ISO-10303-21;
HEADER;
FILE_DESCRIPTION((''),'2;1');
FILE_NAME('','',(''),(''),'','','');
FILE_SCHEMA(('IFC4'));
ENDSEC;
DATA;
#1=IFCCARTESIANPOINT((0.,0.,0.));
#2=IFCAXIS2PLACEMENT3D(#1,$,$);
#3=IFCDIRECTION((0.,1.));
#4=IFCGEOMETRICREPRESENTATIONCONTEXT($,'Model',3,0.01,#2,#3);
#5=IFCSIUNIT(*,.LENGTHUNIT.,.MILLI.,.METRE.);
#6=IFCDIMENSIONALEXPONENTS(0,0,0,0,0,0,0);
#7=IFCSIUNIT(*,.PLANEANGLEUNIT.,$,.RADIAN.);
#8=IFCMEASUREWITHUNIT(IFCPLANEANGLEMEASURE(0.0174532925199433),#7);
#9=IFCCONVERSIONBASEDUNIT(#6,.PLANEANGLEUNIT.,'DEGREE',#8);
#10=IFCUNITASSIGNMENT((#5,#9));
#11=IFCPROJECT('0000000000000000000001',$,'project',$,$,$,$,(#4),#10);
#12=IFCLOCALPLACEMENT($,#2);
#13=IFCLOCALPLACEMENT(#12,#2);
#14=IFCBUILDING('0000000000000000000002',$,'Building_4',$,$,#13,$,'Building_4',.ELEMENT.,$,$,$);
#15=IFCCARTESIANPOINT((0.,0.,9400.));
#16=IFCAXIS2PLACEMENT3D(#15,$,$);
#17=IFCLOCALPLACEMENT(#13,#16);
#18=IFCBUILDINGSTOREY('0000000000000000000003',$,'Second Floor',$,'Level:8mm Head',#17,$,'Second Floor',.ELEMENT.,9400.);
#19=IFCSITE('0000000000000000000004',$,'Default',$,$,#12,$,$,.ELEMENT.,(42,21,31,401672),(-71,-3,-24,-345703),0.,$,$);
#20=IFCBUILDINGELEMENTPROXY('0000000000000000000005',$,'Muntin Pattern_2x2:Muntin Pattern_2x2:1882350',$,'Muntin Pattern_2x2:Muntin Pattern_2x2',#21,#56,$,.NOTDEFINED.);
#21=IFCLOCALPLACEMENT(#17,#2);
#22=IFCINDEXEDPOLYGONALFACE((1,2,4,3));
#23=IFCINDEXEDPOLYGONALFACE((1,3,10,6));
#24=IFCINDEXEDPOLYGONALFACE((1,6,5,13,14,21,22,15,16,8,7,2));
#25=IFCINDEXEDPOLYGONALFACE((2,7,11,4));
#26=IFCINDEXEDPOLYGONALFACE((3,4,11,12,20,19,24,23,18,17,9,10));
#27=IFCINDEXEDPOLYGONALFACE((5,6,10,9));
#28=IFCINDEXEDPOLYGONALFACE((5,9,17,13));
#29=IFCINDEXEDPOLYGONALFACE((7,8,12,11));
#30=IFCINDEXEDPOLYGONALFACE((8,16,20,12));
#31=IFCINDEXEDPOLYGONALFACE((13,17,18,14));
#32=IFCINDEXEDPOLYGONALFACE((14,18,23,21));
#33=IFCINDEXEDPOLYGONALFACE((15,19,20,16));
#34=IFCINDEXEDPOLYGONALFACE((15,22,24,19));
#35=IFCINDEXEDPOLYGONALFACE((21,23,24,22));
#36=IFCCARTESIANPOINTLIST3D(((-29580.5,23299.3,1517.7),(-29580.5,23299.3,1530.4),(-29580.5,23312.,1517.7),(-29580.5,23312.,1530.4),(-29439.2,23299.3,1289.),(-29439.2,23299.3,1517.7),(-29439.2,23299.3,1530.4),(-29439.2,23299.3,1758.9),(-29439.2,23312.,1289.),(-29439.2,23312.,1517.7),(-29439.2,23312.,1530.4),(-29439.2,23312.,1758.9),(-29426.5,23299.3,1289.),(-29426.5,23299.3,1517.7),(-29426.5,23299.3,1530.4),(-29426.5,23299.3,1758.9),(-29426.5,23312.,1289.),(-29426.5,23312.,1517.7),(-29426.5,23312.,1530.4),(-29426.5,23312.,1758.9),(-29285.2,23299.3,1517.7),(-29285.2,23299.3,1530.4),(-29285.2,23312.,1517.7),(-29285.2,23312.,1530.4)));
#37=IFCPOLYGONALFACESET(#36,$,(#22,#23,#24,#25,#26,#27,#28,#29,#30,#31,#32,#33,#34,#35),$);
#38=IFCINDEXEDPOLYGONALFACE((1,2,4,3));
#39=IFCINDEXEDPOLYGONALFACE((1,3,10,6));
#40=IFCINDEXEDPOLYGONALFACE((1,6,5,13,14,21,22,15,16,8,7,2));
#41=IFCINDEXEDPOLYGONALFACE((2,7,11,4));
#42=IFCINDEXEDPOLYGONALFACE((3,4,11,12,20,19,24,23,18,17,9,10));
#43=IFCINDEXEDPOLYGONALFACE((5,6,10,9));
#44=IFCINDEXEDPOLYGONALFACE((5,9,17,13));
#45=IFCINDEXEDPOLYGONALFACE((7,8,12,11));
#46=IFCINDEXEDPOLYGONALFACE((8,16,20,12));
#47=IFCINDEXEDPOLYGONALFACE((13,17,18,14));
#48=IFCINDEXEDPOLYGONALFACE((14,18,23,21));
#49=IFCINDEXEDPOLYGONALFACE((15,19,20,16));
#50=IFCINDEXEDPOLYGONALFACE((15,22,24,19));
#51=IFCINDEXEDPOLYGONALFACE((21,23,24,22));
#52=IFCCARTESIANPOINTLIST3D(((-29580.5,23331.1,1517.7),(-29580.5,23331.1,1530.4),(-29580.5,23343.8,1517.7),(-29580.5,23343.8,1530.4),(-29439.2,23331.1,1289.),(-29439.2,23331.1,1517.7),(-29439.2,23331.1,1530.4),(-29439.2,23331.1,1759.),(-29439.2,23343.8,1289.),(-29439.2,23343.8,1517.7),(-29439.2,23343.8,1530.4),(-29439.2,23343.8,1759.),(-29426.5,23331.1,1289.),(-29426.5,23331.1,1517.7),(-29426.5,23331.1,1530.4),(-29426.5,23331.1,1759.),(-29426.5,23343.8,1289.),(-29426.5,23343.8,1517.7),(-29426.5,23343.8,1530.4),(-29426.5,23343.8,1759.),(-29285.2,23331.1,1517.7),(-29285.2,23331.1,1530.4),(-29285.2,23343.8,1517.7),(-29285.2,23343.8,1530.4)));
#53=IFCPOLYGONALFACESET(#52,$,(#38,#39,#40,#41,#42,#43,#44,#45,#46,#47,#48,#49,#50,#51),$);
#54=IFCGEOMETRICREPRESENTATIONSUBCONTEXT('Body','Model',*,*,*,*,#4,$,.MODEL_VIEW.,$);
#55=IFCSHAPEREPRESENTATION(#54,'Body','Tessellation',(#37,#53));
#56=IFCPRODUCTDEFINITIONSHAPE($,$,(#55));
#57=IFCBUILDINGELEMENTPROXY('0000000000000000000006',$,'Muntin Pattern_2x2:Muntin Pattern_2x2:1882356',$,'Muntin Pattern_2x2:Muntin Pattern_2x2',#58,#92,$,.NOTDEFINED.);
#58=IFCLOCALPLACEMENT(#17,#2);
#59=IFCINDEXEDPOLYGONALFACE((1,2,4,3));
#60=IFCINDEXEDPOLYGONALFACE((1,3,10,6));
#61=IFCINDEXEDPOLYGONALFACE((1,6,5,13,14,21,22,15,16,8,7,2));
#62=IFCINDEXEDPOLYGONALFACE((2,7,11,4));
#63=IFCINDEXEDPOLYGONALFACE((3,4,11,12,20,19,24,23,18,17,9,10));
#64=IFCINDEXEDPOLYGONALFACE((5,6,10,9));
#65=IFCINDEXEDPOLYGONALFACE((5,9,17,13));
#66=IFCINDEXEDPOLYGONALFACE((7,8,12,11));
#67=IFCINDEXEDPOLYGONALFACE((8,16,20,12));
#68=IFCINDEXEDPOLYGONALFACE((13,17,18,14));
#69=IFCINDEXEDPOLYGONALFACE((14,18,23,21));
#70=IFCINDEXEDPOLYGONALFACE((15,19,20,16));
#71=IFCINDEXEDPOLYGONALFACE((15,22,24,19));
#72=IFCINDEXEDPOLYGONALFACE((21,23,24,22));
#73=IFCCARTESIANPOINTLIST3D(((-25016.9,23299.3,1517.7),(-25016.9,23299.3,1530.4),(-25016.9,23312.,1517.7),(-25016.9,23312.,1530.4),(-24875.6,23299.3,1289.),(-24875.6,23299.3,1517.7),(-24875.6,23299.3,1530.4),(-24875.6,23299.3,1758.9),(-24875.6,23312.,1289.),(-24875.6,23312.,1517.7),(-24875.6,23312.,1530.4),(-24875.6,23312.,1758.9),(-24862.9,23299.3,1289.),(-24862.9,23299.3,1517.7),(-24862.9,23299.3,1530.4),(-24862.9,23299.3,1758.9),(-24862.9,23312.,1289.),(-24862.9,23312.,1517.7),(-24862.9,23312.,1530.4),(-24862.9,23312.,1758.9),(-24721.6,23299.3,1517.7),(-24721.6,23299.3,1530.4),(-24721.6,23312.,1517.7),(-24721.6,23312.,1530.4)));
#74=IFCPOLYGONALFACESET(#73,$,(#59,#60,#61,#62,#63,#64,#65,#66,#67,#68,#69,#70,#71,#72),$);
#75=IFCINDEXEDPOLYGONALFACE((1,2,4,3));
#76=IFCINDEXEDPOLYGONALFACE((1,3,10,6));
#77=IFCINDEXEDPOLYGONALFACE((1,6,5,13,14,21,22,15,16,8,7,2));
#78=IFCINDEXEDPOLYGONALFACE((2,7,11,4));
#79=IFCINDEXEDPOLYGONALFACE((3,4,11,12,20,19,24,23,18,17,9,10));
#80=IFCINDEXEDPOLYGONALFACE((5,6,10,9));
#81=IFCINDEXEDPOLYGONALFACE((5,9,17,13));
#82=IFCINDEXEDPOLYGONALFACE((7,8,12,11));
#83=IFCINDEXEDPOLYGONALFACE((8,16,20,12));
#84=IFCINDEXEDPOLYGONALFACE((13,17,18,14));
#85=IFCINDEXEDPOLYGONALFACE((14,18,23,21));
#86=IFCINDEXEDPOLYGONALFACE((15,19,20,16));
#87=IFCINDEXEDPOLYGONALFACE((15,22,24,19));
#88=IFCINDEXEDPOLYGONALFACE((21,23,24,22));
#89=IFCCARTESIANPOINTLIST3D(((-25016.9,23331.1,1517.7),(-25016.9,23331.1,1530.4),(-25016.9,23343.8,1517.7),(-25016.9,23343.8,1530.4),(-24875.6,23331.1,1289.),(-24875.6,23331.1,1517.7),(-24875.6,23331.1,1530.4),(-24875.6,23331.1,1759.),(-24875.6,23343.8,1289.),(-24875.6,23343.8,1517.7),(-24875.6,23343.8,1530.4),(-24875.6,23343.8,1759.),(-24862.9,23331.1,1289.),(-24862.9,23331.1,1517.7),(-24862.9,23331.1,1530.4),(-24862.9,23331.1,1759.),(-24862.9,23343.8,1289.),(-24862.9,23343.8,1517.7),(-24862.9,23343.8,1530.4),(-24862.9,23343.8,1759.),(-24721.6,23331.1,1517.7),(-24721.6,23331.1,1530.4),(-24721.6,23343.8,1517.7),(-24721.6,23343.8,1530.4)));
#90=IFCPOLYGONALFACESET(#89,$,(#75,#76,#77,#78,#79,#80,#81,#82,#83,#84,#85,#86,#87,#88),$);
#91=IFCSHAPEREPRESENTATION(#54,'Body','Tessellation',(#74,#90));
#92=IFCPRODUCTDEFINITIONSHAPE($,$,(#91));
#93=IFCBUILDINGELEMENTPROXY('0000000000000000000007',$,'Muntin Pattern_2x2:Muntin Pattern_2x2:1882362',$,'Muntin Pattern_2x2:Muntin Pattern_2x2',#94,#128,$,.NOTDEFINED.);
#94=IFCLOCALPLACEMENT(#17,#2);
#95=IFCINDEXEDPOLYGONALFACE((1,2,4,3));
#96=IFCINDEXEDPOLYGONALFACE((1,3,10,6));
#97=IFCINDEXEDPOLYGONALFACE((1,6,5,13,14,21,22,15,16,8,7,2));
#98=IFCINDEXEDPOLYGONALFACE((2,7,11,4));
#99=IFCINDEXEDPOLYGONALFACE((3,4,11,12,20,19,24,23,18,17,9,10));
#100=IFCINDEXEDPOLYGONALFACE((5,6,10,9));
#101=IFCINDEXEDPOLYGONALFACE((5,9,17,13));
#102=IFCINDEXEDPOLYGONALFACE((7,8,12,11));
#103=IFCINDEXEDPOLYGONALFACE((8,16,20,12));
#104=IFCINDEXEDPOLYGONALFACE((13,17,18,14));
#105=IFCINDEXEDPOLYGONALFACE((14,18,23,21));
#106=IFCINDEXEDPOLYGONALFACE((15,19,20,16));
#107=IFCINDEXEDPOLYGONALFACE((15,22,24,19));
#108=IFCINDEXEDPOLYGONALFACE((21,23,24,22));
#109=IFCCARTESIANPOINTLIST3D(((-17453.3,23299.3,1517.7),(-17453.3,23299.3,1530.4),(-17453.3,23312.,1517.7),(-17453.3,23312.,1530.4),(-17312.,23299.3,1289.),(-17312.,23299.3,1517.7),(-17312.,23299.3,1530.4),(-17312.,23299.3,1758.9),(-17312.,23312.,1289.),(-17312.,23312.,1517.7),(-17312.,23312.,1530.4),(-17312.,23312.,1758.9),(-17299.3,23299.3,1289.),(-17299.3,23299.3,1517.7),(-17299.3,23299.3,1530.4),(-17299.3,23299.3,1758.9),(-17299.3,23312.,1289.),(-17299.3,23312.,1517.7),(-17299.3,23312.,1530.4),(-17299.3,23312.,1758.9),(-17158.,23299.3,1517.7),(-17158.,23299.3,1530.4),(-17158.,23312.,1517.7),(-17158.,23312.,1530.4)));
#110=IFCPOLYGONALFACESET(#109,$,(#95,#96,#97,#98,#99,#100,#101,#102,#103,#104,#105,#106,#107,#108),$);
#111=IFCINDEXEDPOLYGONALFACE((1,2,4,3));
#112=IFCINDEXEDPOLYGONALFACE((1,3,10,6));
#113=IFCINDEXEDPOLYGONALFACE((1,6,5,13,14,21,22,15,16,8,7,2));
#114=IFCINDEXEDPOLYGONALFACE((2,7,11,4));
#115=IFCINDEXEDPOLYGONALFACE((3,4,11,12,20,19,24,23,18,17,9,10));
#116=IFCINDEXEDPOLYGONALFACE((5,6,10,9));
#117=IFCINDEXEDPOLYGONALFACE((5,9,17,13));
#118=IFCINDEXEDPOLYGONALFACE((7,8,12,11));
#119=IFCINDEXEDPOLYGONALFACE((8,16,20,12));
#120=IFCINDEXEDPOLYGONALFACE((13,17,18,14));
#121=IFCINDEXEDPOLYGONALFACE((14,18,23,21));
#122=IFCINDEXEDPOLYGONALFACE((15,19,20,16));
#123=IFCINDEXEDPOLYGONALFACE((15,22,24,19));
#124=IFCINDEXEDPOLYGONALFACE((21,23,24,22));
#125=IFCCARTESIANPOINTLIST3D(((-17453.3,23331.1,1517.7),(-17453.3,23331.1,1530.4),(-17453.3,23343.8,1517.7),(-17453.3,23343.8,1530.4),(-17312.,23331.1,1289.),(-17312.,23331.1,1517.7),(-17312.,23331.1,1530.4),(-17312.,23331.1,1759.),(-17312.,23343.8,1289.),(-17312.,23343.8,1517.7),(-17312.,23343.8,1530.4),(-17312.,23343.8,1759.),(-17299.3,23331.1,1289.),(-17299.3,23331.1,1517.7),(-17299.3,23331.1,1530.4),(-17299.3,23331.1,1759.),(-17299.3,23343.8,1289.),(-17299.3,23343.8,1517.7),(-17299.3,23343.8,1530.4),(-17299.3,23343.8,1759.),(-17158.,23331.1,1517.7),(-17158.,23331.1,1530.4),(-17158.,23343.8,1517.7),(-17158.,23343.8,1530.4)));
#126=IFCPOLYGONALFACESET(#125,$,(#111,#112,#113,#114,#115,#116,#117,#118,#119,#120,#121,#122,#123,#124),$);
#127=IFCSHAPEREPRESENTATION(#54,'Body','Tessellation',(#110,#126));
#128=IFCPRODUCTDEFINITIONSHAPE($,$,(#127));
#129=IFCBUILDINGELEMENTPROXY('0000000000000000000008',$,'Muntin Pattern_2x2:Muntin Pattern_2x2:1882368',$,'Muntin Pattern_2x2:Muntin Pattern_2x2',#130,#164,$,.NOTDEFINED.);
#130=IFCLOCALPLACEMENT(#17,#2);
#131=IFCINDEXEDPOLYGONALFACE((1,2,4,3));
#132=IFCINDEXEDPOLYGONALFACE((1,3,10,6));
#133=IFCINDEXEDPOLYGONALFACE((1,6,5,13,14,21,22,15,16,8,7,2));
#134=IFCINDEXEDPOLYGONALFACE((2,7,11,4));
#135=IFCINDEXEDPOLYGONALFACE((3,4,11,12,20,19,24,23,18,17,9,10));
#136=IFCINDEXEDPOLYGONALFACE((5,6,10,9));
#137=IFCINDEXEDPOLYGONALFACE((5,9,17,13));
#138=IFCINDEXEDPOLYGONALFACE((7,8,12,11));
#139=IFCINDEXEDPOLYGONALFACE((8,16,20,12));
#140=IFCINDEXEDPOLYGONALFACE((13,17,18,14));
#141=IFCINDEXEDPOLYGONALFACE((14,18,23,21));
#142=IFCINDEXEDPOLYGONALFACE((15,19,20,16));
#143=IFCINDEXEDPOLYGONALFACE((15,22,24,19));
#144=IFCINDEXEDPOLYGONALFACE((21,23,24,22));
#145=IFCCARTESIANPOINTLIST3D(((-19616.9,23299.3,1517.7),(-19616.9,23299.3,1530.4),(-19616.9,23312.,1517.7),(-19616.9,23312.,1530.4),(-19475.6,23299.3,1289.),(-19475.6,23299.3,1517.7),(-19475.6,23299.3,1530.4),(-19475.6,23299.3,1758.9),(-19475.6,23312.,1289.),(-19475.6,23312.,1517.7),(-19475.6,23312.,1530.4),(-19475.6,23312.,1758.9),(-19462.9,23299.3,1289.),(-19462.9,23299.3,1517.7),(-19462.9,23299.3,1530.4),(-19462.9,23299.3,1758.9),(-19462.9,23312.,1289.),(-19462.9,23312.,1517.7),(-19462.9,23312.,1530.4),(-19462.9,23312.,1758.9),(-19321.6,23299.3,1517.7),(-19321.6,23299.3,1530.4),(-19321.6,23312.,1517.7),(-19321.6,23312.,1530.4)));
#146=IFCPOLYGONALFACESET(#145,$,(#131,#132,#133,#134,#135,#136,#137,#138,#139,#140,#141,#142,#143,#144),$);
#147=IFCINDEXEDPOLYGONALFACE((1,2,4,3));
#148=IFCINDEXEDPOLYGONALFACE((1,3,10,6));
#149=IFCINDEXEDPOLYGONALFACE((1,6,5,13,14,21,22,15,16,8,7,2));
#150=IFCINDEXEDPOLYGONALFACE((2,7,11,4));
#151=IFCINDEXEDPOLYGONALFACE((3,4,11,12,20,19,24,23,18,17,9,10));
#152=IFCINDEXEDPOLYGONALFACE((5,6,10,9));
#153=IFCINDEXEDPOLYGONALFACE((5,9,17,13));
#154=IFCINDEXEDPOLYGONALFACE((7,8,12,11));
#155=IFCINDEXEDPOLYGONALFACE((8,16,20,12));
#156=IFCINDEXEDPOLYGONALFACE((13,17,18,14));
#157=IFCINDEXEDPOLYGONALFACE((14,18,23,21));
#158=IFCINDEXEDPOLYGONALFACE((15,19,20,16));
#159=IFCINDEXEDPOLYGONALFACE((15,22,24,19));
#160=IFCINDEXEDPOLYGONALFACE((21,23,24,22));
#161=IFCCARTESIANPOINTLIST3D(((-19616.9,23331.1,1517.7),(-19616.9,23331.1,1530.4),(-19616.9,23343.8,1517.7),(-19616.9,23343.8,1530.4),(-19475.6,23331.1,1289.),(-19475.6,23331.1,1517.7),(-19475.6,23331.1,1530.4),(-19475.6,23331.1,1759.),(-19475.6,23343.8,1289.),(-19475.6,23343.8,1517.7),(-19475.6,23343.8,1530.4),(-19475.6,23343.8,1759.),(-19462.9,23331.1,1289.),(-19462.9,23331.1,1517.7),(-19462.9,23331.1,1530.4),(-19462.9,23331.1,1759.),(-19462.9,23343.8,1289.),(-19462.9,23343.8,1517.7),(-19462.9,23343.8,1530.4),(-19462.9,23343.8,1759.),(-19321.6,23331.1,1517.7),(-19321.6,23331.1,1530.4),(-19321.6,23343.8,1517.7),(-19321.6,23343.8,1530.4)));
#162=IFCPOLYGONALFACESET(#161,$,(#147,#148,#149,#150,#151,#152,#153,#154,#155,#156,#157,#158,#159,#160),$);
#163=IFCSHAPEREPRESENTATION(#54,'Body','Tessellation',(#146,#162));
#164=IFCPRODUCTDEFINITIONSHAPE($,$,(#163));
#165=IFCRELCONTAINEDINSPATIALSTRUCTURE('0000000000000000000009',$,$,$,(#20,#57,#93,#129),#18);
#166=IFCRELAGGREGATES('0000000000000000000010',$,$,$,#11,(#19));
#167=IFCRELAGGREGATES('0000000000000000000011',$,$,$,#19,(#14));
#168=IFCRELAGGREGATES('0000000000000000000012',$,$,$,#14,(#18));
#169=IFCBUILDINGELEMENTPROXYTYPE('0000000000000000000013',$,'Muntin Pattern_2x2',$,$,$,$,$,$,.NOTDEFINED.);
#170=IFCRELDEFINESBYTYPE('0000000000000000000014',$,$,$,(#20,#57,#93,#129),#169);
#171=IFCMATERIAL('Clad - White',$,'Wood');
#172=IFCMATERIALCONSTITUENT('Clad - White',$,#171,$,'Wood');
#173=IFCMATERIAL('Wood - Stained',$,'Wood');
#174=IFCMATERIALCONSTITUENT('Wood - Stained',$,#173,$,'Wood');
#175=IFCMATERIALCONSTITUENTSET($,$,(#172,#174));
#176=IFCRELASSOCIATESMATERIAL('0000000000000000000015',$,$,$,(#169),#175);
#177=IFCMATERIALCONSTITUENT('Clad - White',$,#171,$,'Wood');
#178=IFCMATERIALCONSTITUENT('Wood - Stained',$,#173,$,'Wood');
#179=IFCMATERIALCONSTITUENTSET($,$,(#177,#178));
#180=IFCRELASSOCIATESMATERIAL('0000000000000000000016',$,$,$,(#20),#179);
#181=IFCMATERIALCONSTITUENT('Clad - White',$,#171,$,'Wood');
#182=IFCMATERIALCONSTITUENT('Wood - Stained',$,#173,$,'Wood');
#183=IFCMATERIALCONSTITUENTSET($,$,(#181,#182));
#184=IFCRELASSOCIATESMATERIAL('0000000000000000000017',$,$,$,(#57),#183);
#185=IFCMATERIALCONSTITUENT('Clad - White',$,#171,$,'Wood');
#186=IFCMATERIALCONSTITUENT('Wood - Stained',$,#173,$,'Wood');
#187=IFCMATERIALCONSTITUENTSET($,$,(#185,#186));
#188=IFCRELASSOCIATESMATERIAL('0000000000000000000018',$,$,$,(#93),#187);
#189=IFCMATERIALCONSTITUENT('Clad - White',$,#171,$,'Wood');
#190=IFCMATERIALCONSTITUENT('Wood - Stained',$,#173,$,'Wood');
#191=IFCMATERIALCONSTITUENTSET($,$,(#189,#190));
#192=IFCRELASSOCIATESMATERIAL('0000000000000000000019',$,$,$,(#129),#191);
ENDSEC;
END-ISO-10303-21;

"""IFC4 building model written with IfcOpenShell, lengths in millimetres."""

from ifc_helpers import new_model, entity, si_unit, converted_unit, direction, frame, origin, place, context, subcontext, project, spatial, indexed_curve, outline, extrude, source, transform, mapped, material, constituent, constituent_set, type_object, type_shapes, element, save


model = new_model("IFC4")

# Units and contexts
model_context = context("Model", 3, precision=0.01, world=origin(), true_north=direction((0.0, 1.0)))
body_context = subcontext(model_context, "Body", "Model", "MODEL_VIEW")
ifc_project = project(units=[si_unit("LENGTHUNIT", "METRE", prefix="MILLI"), converted_unit("PLANEANGLEUNIT", "DEGREE", entity("IfcPlaneAngleMeasure", 0.0174532925199433), si_unit("PLANEANGLEUNIT", "RADIAN"), dimensions=[0, 0, 0, 0, 0, 0, 0])], contexts=[model_context])

# Site, building, storey
site_placement = place(None, origin())
site = spatial("IfcSite", under=ifc_project, at=site_placement, Name="Default", CompositionType="ELEMENT", RefLatitude=(42, 21, 31, 401672), RefLongitude=(-71, -3, -24, -345703), RefElevation=0.0)
building_placement = place(site_placement, origin())
building = spatial("IfcBuilding", under=site, at=building_placement, Name="Building_4", LongName="Building_4", CompositionType="ELEMENT")
storey_placement = place(building_placement, frame((0.0, 0.0, 9400.0)))
storey = spatial("IfcBuildingStorey", under=building, at=storey_placement, Name="Second Floor", ObjectType="Level:8mm Head", LongName="Second Floor", CompositionType="ELEMENT", Elevation=9400.0)

# Building element proxies
ifc_material_1 = material(Name="Clad - White", Category="Wood")
ifc_material_2 = material(Name="Wood - Stained", Category="Wood")
ifc_constituent_1 = constituent(ifc_material_1, Name="Clad - White", Category="Wood")
ifc_constituent_2 = constituent(ifc_material_2, Name="Wood - Stained", Category="Wood")
ifc_constituent_set_1 = constituent_set(constituents=[ifc_constituent_1, ifc_constituent_2])
ifc_constituent_3 = constituent(ifc_material_1, Name="Clad - White", Category="Wood")
ifc_constituent_4 = constituent(ifc_material_2, Name="Wood - Stained", Category="Wood")
ifc_constituent_set_2 = constituent_set(constituents=[ifc_constituent_3, ifc_constituent_4])
building_element_proxy_type_1 = type_object("IfcBuildingElementProxyType", Name="Muntin Pattern_2x2", PredefinedType="NOTDEFINED", material=ifc_constituent_set_2)
shared_shape_1 = source(origin(), body_context, "Body", "SweptSolid", [
    extrude(outline(indexed_curve([(6.4, -6.4), (234.9, -6.4), (234.9, 6.3), (6.4, 6.3), (6.4, 147.6), (-6.3, 147.6), (-6.3, 6.3), (-235.0, 6.3), (-235.0, -6.4), (-6.3, -6.4), (-6.3, -147.6), (6.4, -147.6), (6.4, -6.4)], self_intersect=False)), frame((0.0, 9.5, 235.0), z_axis=(0.0, 1.0, 0.0), x_axis=(0.0, 0.0, 1.0)), (0.0, 0.0, 1.0), 12.7),
    extrude(outline(indexed_curve([(6.4, -6.4), (235.0, -6.4), (235.0, 6.3), (6.4, 6.3), (6.4, 147.6), (-6.3, 147.6), (-6.3, 6.3), (-235.0, 6.3), (-235.0, -6.4), (-6.3, -6.4), (-6.3, -147.6), (6.4, -147.6), (6.4, -6.4)], self_intersect=False)), frame((0.0, -22.2, 235.0), z_axis=(0.0, 1.0, 0.0), x_axis=(0.0, 0.0, 1.0)), (0.0, 0.0, 1.0), 12.7),
])
type_shapes(building_element_proxy_type_1, [shared_shape_1])
proxy_1_placement = place(storey_placement, frame((-29432.9, 23321.5, 1289.0), z_axis=(0.0, 0.0, 1.0), x_axis=(-1.0, 0.0, 0.0)))
element("IfcBuildingElementProxy", 1, at=proxy_1_placement, inside=storey, type_object=building_element_proxy_type_1, material=ifc_constituent_set_1, Name="Muntin Pattern_2x2:Muntin Pattern_2x2:1882350", ObjectType="Muntin Pattern_2x2:Muntin Pattern_2x2", PredefinedType="NOTDEFINED", context=body_context, shape_type="MappedRepresentation", body=[
    mapped(shared_shape_1, transform((0.0, 0.0, 0.0), scale=1.0)),
])
ifc_constituent_5 = constituent(ifc_material_1, Name="Clad - White", Category="Wood")
ifc_constituent_6 = constituent(ifc_material_2, Name="Wood - Stained", Category="Wood")
ifc_constituent_set_3 = constituent_set(constituents=[ifc_constituent_5, ifc_constituent_6])
proxy_2_placement = place(storey_placement, frame((-24869.3, 23321.5, 1289.0), z_axis=(0.0, 0.0, 1.0), x_axis=(-1.0, 0.0, 0.0)))
element("IfcBuildingElementProxy", 2, at=proxy_2_placement, inside=storey, type_object=building_element_proxy_type_1, material=ifc_constituent_set_3, Name="Muntin Pattern_2x2:Muntin Pattern_2x2:1882356", ObjectType="Muntin Pattern_2x2:Muntin Pattern_2x2", PredefinedType="NOTDEFINED", context=body_context, shape_type="MappedRepresentation", body=[
    mapped(shared_shape_1, transform((0.0, 0.0, 0.0), scale=1.0)),
])
ifc_constituent_7 = constituent(ifc_material_1, Name="Clad - White", Category="Wood")
ifc_constituent_8 = constituent(ifc_material_2, Name="Wood - Stained", Category="Wood")
ifc_constituent_set_4 = constituent_set(constituents=[ifc_constituent_7, ifc_constituent_8])
proxy_3_placement = place(storey_placement, frame((-17305.7, 23321.5, 1289.0), z_axis=(0.0, 0.0, 1.0), x_axis=(-1.0, 0.0, 0.0)))
element("IfcBuildingElementProxy", 3, at=proxy_3_placement, inside=storey, type_object=building_element_proxy_type_1, material=ifc_constituent_set_4, Name="Muntin Pattern_2x2:Muntin Pattern_2x2:1882362", ObjectType="Muntin Pattern_2x2:Muntin Pattern_2x2", PredefinedType="NOTDEFINED", context=body_context, shape_type="MappedRepresentation", body=[
    mapped(shared_shape_1, transform((0.0, 0.0, 0.0), scale=1.0)),
])
ifc_constituent_9 = constituent(ifc_material_1, Name="Clad - White", Category="Wood")
ifc_constituent_10 = constituent(ifc_material_2, Name="Wood - Stained", Category="Wood")
ifc_constituent_set_5 = constituent_set(constituents=[ifc_constituent_9, ifc_constituent_10])
proxy_4_placement = place(storey_placement, frame((-19469.3, 23321.5, 1289.0), z_axis=(0.0, 0.0, 1.0), x_axis=(-1.0, 0.0, 0.0)))
element("IfcBuildingElementProxy", 4, at=proxy_4_placement, inside=storey, type_object=building_element_proxy_type_1, material=ifc_constituent_set_5, Name="Muntin Pattern_2x2:Muntin Pattern_2x2:1882368", ObjectType="Muntin Pattern_2x2:Muntin Pattern_2x2", PredefinedType="NOTDEFINED", context=body_context, shape_type="MappedRepresentation", body=[
    mapped(shared_shape_1, transform((0.0, 0.0, 0.0), scale=1.0)),
])

save(model, "model.ifc")
